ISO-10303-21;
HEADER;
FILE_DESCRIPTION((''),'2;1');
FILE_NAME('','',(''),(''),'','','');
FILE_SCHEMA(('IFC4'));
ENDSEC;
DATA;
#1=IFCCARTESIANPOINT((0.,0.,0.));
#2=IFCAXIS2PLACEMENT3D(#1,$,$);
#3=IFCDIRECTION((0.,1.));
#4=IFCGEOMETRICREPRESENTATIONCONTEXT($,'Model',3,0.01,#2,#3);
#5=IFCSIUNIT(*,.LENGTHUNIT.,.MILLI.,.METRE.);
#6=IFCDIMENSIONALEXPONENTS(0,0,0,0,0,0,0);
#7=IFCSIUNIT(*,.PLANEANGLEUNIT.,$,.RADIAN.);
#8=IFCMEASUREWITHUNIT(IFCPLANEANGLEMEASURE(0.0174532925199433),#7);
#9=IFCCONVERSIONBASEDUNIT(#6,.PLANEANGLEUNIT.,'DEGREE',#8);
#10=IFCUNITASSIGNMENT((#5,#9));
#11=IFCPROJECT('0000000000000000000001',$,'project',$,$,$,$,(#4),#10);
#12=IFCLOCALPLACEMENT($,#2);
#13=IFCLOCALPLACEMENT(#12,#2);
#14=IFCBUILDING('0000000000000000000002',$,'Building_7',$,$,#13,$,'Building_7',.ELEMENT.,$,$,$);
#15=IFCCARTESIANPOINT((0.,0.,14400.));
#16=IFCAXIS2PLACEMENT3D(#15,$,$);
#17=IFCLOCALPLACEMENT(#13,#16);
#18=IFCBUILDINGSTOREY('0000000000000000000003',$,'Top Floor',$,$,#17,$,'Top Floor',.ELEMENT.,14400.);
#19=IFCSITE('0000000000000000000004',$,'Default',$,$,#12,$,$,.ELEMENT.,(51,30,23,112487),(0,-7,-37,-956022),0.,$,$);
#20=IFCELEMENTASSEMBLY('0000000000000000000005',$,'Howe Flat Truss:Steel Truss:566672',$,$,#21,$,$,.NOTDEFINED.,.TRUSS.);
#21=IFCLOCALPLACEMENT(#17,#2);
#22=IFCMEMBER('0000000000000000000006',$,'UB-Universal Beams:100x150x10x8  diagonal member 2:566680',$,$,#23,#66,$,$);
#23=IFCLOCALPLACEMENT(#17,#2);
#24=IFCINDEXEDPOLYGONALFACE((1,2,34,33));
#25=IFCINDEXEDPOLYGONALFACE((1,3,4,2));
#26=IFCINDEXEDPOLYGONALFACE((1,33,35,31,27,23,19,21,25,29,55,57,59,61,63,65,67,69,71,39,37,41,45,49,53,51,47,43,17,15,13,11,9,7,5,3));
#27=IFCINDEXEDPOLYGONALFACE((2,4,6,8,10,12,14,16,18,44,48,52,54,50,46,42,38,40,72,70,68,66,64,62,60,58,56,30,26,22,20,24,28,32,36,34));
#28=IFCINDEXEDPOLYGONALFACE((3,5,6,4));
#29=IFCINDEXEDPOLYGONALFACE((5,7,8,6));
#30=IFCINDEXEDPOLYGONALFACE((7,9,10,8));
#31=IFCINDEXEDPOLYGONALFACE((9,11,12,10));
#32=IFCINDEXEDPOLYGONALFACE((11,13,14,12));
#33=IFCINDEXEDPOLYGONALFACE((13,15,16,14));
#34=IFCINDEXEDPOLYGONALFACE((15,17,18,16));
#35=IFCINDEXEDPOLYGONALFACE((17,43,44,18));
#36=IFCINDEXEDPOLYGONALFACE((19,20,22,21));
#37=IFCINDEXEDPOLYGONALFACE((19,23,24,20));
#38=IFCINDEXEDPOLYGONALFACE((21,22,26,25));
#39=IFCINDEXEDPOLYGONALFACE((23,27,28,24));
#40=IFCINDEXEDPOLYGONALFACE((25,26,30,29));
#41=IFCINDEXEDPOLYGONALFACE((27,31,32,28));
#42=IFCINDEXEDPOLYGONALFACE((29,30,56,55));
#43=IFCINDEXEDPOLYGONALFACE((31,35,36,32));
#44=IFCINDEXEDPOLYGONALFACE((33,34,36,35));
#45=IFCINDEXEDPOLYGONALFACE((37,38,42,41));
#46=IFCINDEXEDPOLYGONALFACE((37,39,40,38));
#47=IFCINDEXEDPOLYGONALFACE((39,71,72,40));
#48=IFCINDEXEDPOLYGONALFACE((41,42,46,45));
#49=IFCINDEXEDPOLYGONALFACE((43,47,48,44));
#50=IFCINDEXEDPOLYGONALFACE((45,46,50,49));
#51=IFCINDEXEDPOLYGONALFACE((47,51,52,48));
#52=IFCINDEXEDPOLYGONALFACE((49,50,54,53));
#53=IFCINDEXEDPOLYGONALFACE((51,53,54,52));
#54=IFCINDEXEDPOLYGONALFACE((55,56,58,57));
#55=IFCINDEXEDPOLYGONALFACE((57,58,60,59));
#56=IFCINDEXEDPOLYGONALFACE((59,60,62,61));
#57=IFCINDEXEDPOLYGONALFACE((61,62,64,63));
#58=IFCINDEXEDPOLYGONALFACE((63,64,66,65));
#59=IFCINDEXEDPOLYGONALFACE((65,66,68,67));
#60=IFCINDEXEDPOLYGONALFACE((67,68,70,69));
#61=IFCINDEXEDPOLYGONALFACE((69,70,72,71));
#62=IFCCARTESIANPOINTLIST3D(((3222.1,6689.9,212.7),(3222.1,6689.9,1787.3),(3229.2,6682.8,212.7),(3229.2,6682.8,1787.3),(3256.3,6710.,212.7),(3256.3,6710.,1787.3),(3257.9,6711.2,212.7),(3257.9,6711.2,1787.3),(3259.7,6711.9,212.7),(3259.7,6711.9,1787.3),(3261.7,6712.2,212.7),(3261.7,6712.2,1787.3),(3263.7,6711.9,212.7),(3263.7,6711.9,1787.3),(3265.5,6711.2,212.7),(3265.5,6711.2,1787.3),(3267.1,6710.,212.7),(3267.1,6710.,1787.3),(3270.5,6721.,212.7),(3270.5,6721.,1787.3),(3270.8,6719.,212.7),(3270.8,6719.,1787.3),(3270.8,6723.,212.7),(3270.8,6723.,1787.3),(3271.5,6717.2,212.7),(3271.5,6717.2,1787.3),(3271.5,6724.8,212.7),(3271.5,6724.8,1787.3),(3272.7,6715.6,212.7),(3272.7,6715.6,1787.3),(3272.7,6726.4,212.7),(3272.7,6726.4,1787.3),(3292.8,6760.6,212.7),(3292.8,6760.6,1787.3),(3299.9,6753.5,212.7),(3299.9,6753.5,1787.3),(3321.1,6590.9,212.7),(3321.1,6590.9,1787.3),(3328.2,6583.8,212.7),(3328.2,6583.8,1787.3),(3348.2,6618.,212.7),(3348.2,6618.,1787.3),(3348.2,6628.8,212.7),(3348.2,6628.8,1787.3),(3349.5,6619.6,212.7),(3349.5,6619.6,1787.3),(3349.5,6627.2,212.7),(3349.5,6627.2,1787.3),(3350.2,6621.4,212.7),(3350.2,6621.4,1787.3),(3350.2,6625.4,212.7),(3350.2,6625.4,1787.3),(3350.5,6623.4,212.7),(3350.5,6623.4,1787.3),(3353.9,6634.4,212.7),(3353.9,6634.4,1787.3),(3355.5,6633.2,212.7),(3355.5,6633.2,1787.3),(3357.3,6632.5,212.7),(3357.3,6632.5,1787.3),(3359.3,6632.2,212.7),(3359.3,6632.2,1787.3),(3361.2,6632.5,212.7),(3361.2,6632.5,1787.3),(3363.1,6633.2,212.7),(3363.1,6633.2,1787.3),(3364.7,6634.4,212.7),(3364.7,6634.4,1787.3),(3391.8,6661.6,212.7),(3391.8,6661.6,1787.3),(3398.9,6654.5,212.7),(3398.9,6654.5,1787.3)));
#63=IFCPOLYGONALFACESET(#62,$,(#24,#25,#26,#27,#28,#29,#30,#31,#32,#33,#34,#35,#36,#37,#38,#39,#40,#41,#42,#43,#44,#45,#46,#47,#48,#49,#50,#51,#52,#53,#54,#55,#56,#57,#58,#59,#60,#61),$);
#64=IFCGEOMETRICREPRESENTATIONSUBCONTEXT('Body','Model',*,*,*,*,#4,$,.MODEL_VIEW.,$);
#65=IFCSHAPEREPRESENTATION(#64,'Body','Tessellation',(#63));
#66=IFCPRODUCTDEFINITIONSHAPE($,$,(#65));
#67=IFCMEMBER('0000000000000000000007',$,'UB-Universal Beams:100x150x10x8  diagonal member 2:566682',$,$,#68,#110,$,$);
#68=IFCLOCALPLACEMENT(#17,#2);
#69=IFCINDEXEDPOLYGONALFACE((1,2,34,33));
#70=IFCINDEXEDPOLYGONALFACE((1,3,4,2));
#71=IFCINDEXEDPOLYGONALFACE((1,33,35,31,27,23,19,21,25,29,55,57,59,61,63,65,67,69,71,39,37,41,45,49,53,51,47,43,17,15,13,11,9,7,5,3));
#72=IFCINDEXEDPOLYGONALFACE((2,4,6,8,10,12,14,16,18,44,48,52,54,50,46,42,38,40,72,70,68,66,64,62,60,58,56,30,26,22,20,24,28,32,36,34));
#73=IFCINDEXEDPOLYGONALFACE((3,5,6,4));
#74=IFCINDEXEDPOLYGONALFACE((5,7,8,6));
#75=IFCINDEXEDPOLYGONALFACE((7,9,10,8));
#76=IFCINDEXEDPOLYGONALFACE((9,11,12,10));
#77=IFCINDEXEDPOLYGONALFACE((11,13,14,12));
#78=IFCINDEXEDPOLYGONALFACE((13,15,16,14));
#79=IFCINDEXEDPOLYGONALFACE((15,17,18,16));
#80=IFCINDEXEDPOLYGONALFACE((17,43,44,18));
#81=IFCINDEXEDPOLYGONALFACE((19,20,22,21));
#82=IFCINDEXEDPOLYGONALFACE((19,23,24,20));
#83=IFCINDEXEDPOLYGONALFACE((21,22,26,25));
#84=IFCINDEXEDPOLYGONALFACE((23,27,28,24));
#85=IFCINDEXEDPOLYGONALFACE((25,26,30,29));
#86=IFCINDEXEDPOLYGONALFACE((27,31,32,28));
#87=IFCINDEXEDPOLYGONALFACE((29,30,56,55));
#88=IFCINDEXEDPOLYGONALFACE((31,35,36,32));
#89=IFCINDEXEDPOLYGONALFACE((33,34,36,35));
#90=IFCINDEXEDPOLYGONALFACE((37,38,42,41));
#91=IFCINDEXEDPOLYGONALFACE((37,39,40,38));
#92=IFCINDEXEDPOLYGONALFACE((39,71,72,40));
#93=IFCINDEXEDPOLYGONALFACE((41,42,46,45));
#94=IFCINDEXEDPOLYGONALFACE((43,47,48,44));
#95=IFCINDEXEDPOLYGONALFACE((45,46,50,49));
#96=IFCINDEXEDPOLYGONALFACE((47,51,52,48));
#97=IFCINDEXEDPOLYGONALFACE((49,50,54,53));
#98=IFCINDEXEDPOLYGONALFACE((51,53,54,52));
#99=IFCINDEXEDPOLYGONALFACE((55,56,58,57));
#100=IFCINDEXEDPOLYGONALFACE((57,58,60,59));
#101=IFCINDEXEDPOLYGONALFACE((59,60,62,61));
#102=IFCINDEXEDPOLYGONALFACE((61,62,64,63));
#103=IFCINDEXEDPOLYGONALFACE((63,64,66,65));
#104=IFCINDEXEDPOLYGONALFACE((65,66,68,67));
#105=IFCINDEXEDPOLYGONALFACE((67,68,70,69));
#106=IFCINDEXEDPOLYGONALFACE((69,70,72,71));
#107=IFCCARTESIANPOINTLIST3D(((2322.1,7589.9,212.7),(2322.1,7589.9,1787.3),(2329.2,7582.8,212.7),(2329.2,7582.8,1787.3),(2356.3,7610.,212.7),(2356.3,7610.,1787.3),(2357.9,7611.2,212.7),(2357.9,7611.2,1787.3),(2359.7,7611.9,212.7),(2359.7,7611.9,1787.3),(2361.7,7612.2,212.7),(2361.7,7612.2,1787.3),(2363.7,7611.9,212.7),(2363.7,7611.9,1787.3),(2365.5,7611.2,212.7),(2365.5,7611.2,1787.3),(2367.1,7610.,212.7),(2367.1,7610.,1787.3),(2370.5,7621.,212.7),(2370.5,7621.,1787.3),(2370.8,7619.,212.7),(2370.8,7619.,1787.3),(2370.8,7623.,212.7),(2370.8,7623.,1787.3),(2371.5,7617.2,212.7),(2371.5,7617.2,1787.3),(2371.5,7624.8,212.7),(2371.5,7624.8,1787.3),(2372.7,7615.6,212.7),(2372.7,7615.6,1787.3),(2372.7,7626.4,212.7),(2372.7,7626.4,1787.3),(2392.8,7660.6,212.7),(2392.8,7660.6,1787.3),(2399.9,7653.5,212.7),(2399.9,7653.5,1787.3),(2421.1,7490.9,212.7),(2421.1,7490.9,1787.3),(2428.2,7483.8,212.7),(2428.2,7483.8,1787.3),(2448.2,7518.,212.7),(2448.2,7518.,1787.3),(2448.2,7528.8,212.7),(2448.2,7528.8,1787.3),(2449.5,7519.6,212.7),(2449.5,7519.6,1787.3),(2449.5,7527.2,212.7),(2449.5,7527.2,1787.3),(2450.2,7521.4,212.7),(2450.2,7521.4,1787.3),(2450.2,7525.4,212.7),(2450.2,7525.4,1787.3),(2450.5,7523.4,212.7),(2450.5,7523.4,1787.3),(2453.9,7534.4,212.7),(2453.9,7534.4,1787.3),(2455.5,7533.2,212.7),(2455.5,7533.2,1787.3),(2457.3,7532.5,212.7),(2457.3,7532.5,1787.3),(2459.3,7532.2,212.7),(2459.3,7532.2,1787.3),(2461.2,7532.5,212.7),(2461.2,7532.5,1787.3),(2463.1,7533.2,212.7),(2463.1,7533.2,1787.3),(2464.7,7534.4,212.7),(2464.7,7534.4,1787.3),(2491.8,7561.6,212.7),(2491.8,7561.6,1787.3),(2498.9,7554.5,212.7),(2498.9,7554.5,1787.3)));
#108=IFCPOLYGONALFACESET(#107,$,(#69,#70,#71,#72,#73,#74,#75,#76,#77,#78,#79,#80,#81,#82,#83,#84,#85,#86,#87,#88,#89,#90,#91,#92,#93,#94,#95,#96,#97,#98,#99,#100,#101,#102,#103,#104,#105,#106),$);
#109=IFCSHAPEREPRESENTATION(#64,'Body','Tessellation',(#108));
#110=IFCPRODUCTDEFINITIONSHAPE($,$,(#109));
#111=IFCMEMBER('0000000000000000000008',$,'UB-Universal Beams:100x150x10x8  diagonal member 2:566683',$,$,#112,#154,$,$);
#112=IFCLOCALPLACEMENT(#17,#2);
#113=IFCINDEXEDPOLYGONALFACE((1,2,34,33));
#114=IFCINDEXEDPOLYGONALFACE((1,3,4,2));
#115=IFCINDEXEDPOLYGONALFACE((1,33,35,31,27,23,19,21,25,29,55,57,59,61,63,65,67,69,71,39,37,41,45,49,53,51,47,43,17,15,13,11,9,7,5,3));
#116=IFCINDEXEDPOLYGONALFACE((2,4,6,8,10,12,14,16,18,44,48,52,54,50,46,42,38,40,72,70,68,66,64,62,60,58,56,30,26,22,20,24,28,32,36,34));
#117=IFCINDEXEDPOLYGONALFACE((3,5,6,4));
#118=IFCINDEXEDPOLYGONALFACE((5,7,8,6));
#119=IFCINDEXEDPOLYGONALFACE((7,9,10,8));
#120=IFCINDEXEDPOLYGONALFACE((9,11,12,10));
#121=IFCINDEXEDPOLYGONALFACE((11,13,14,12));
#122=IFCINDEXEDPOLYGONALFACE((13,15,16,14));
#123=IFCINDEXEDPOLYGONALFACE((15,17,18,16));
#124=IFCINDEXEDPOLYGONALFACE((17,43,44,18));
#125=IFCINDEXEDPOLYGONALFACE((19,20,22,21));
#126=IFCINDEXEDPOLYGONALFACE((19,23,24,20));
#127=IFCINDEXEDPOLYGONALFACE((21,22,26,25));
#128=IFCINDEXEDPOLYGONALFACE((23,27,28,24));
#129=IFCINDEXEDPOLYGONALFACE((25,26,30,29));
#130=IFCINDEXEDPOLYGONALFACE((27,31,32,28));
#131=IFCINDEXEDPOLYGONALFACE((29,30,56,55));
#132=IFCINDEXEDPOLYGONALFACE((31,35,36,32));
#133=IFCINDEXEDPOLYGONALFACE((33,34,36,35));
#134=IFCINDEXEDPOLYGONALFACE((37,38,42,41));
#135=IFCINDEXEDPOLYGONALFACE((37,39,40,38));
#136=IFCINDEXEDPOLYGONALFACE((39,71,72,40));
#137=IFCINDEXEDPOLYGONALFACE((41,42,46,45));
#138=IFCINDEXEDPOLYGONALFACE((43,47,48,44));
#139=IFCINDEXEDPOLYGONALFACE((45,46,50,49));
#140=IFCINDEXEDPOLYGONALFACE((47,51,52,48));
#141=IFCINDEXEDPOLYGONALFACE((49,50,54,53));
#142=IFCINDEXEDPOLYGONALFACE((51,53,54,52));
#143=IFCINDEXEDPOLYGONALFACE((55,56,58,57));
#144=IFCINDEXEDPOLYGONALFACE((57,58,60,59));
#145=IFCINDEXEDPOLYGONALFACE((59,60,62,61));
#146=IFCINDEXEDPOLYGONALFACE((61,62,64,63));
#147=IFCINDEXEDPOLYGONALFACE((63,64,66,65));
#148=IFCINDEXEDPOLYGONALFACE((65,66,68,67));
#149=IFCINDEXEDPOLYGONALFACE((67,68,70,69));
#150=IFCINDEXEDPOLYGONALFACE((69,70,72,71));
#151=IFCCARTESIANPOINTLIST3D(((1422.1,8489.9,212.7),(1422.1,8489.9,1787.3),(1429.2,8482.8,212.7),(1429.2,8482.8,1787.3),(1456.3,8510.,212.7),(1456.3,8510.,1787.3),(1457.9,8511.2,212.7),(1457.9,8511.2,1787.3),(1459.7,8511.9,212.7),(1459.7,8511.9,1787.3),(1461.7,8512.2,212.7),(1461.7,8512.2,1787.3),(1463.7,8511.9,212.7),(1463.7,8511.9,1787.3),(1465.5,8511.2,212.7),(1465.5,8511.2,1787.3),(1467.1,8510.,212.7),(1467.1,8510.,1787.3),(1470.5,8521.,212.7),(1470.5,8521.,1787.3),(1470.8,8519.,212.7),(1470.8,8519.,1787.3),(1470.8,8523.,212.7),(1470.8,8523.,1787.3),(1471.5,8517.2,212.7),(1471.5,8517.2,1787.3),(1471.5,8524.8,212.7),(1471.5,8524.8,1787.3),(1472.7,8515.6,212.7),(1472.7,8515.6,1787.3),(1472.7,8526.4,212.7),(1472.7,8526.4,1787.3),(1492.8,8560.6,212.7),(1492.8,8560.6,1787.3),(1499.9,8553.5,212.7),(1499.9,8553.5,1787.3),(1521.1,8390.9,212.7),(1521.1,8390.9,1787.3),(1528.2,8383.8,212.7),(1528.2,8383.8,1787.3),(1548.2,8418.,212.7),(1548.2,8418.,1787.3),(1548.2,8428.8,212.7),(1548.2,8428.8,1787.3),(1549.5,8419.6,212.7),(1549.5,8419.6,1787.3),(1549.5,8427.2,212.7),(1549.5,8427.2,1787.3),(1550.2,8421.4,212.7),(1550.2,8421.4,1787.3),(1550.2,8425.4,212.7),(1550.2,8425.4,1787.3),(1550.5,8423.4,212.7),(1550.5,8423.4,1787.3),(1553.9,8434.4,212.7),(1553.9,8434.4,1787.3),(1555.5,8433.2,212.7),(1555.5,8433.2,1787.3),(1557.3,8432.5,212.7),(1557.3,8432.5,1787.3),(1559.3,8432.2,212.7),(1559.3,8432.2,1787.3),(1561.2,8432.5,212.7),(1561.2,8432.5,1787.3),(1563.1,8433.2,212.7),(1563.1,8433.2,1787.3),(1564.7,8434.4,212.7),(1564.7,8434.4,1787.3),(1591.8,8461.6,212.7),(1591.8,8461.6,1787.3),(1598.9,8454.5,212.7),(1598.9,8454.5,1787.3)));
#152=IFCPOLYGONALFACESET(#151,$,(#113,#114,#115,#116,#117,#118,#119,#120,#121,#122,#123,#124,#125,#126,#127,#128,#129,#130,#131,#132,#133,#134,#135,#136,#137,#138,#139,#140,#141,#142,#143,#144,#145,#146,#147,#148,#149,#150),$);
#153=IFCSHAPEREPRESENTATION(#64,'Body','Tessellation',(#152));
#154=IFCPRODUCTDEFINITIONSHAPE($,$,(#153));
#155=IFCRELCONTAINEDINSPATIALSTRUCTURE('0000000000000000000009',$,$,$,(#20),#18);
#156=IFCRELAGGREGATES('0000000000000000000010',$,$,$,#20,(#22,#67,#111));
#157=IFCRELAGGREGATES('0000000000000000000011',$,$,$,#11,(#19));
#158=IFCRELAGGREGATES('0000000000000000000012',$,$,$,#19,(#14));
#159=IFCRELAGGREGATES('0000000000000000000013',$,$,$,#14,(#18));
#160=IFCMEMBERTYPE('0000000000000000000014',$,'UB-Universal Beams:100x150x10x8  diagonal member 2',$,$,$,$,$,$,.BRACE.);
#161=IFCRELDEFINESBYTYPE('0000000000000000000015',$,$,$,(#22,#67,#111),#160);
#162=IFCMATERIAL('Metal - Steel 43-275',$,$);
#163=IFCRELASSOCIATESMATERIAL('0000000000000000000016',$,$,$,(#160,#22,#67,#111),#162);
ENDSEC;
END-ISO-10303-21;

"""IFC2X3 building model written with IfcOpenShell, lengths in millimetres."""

from ifc_helpers import new_model, entity, si_unit, converted_unit, direction, frame, frame_2d, origin, place, context, subcontext, project, spatial, polyline, circle_curve, parameter, trimmed, segment, composite_curve, outline, extrude, source, transform, mapped, material, type_object, type_shapes, element, aggregate, save


model = new_model("IFC2X3")

# Units and contexts
model_context = context("Model", 3, precision=0.01, world=origin(), true_north=direction((0.0, 1.0)))
body_context = subcontext(model_context, "Body", "Model", "MODEL_VIEW")
ifc_project = project(units=[si_unit("LENGTHUNIT", "METRE", prefix="MILLI"), converted_unit("PLANEANGLEUNIT", "DEGREE", entity("IfcPlaneAngleMeasure", 0.0174532925199433), si_unit("PLANEANGLEUNIT", "RADIAN"), dimensions=[0, 0, 0, 0, 0, 0, 0])], contexts=[model_context])

# Site, building, storey
site_placement = place(None, origin())
site = spatial("IfcSite", under=ifc_project, at=site_placement, Name="Default", CompositionType="ELEMENT", RefLatitude=(51, 30, 23, 112487), RefLongitude=(0, -7, -37, -956022), RefElevation=0.0)
building_placement = place(site_placement, origin())
building = spatial("IfcBuilding", under=site, at=building_placement, Name="Building_7", LongName="Building_7", CompositionType="ELEMENT")
storey_placement = place(building_placement, frame((0.0, 0.0, 14400.0)))
storey = spatial("IfcBuildingStorey", under=building, at=storey_placement, Name="Top Floor", LongName="Top Floor", CompositionType="ELEMENT", Elevation=14400.0)

# Shared definitions
ifc_material = material(Name="Metal - Steel 43-275")

# Element assembly, members
member_type_1 = type_object("IfcMemberType", Name="UB-Universal Beams:100x150x10x8  diagonal member 2", PredefinedType="BRACE", material=ifc_material)
shared_shape_1 = source(origin(), body_context, "Body", "SweptSolid", [
    extrude(outline(composite_curve([segment(polyline([(-50.0, -65.0), (-50.0, -75.0)]), True, "CONTINUOUS"), segment(polyline([(-50.0, -75.0), (50.0, -75.0)]), True, "CONTINUOUS"), segment(polyline([(50.0, -75.0), (50.0, -65.0)]), True, "CONTINUOUS"), segment(polyline([(50.0, -65.0), (11.6, -65.0)]), True, "CONTINUOUS"), segment(trimmed(circle_curve(frame_2d((11.6, -57.4), x_axis=(1.0, 0.0)), 7.6), [parameter(180.0)], [parameter(270.0)], True, "PARAMETER"), False, "CONTINUOUS"), segment(polyline([(4.0, -57.4), (4.0, 57.4)]), True, "CONTINUOUS"), segment(trimmed(circle_curve(frame_2d((11.6, 57.4), x_axis=(1.0, 0.0)), 7.6), [parameter(90.0)], [parameter(180.0)], True, "PARAMETER"), False, "CONTINUOUS"), segment(polyline([(11.6, 65.0), (50.0, 65.0)]), True, "CONTINUOUS"), segment(polyline([(50.0, 65.0), (50.0, 75.0)]), True, "CONTINUOUS"), segment(polyline([(50.0, 75.0), (-50.0, 75.0)]), True, "CONTINUOUS"), segment(polyline([(-50.0, 75.0), (-50.0, 65.0)]), True, "CONTINUOUS"), segment(polyline([(-50.0, 65.0), (-11.6, 65.0)]), True, "CONTINUOUS"), segment(trimmed(circle_curve(frame_2d((-11.6, 57.4), x_axis=(1.0, 0.0)), 7.6), [parameter(360.0)], [parameter(90.0)], True, "PARAMETER"), False, "CONTINUOUS"), segment(polyline([(-4.0, 57.4), (-4.0, -57.4)]), True, "CONTINUOUS"), segment(trimmed(circle_curve(frame_2d((-11.6, -57.4), x_axis=(1.0, 0.0)), 7.6), [parameter(270.0)], [parameter(360.0)], True, "PARAMETER"), False, "CONTINUOUS"), segment(polyline([(-11.6, -65.0), (-50.0, -65.0)]), True, "CONTINUOUS")], self_intersect=False)), frame((-787.3, 0.0, 0.0), z_axis=(-1.0, 0.0, 0.0), x_axis=(0.0, -1.0, 0.0)), (0.0, 0.0, -1.0), 1574.6),
])
type_shapes(member_type_1, [shared_shape_1])
assembly_1_placement = place(storey_placement, origin())
assembly_1 = element("IfcElementAssembly", 1, at=assembly_1_placement, inside=storey, Name="Howe Flat Truss:Steel Truss:566672", AssemblyPlace="NOTDEFINED", PredefinedType="TRUSS")
member_1_placement = place(assembly_1_placement, frame((3310.5, 6672.2, 1000.0), z_axis=(-0.707107, 0.707107, 0.0), x_axis=(0.0, 0.0, 1.0)))
member_1 = element("IfcMember", 2, at=member_1_placement, type_object=member_type_1, material=ifc_material, Name="UB-Universal Beams:100x150x10x8  diagonal member 2:566680", context=body_context, shape_type="MappedRepresentation", body=[
    mapped(shared_shape_1, transform((0.0, 0.0, 0.0), scale=1.0)),
])
member_2_placement = place(assembly_1_placement, frame((2410.5, 7572.2, 1000.0), z_axis=(-0.707107, 0.707107, 0.0), x_axis=(0.0, 0.0, 1.0)))
member_2 = element("IfcMember", 3, at=member_2_placement, type_object=member_type_1, material=ifc_material, Name="UB-Universal Beams:100x150x10x8  diagonal member 2:566682", context=body_context, shape_type="MappedRepresentation", body=[
    mapped(shared_shape_1, transform((0.0, 0.0, 0.0), scale=1.0)),
])
member_3_placement = place(assembly_1_placement, frame((1510.5, 8472.2, 1000.0), z_axis=(-0.707107, 0.707107, 0.0), x_axis=(0.0, 0.0, 1.0)))
member_3 = element("IfcMember", 4, at=member_3_placement, type_object=member_type_1, material=ifc_material, Name="UB-Universal Beams:100x150x10x8  diagonal member 2:566683", context=body_context, shape_type="MappedRepresentation", body=[
    mapped(shared_shape_1, transform((0.0, 0.0, 0.0), scale=1.0)),
])

aggregate(assembly_1, [member_1, member_2, member_3])

save(model, "model.ifc")
